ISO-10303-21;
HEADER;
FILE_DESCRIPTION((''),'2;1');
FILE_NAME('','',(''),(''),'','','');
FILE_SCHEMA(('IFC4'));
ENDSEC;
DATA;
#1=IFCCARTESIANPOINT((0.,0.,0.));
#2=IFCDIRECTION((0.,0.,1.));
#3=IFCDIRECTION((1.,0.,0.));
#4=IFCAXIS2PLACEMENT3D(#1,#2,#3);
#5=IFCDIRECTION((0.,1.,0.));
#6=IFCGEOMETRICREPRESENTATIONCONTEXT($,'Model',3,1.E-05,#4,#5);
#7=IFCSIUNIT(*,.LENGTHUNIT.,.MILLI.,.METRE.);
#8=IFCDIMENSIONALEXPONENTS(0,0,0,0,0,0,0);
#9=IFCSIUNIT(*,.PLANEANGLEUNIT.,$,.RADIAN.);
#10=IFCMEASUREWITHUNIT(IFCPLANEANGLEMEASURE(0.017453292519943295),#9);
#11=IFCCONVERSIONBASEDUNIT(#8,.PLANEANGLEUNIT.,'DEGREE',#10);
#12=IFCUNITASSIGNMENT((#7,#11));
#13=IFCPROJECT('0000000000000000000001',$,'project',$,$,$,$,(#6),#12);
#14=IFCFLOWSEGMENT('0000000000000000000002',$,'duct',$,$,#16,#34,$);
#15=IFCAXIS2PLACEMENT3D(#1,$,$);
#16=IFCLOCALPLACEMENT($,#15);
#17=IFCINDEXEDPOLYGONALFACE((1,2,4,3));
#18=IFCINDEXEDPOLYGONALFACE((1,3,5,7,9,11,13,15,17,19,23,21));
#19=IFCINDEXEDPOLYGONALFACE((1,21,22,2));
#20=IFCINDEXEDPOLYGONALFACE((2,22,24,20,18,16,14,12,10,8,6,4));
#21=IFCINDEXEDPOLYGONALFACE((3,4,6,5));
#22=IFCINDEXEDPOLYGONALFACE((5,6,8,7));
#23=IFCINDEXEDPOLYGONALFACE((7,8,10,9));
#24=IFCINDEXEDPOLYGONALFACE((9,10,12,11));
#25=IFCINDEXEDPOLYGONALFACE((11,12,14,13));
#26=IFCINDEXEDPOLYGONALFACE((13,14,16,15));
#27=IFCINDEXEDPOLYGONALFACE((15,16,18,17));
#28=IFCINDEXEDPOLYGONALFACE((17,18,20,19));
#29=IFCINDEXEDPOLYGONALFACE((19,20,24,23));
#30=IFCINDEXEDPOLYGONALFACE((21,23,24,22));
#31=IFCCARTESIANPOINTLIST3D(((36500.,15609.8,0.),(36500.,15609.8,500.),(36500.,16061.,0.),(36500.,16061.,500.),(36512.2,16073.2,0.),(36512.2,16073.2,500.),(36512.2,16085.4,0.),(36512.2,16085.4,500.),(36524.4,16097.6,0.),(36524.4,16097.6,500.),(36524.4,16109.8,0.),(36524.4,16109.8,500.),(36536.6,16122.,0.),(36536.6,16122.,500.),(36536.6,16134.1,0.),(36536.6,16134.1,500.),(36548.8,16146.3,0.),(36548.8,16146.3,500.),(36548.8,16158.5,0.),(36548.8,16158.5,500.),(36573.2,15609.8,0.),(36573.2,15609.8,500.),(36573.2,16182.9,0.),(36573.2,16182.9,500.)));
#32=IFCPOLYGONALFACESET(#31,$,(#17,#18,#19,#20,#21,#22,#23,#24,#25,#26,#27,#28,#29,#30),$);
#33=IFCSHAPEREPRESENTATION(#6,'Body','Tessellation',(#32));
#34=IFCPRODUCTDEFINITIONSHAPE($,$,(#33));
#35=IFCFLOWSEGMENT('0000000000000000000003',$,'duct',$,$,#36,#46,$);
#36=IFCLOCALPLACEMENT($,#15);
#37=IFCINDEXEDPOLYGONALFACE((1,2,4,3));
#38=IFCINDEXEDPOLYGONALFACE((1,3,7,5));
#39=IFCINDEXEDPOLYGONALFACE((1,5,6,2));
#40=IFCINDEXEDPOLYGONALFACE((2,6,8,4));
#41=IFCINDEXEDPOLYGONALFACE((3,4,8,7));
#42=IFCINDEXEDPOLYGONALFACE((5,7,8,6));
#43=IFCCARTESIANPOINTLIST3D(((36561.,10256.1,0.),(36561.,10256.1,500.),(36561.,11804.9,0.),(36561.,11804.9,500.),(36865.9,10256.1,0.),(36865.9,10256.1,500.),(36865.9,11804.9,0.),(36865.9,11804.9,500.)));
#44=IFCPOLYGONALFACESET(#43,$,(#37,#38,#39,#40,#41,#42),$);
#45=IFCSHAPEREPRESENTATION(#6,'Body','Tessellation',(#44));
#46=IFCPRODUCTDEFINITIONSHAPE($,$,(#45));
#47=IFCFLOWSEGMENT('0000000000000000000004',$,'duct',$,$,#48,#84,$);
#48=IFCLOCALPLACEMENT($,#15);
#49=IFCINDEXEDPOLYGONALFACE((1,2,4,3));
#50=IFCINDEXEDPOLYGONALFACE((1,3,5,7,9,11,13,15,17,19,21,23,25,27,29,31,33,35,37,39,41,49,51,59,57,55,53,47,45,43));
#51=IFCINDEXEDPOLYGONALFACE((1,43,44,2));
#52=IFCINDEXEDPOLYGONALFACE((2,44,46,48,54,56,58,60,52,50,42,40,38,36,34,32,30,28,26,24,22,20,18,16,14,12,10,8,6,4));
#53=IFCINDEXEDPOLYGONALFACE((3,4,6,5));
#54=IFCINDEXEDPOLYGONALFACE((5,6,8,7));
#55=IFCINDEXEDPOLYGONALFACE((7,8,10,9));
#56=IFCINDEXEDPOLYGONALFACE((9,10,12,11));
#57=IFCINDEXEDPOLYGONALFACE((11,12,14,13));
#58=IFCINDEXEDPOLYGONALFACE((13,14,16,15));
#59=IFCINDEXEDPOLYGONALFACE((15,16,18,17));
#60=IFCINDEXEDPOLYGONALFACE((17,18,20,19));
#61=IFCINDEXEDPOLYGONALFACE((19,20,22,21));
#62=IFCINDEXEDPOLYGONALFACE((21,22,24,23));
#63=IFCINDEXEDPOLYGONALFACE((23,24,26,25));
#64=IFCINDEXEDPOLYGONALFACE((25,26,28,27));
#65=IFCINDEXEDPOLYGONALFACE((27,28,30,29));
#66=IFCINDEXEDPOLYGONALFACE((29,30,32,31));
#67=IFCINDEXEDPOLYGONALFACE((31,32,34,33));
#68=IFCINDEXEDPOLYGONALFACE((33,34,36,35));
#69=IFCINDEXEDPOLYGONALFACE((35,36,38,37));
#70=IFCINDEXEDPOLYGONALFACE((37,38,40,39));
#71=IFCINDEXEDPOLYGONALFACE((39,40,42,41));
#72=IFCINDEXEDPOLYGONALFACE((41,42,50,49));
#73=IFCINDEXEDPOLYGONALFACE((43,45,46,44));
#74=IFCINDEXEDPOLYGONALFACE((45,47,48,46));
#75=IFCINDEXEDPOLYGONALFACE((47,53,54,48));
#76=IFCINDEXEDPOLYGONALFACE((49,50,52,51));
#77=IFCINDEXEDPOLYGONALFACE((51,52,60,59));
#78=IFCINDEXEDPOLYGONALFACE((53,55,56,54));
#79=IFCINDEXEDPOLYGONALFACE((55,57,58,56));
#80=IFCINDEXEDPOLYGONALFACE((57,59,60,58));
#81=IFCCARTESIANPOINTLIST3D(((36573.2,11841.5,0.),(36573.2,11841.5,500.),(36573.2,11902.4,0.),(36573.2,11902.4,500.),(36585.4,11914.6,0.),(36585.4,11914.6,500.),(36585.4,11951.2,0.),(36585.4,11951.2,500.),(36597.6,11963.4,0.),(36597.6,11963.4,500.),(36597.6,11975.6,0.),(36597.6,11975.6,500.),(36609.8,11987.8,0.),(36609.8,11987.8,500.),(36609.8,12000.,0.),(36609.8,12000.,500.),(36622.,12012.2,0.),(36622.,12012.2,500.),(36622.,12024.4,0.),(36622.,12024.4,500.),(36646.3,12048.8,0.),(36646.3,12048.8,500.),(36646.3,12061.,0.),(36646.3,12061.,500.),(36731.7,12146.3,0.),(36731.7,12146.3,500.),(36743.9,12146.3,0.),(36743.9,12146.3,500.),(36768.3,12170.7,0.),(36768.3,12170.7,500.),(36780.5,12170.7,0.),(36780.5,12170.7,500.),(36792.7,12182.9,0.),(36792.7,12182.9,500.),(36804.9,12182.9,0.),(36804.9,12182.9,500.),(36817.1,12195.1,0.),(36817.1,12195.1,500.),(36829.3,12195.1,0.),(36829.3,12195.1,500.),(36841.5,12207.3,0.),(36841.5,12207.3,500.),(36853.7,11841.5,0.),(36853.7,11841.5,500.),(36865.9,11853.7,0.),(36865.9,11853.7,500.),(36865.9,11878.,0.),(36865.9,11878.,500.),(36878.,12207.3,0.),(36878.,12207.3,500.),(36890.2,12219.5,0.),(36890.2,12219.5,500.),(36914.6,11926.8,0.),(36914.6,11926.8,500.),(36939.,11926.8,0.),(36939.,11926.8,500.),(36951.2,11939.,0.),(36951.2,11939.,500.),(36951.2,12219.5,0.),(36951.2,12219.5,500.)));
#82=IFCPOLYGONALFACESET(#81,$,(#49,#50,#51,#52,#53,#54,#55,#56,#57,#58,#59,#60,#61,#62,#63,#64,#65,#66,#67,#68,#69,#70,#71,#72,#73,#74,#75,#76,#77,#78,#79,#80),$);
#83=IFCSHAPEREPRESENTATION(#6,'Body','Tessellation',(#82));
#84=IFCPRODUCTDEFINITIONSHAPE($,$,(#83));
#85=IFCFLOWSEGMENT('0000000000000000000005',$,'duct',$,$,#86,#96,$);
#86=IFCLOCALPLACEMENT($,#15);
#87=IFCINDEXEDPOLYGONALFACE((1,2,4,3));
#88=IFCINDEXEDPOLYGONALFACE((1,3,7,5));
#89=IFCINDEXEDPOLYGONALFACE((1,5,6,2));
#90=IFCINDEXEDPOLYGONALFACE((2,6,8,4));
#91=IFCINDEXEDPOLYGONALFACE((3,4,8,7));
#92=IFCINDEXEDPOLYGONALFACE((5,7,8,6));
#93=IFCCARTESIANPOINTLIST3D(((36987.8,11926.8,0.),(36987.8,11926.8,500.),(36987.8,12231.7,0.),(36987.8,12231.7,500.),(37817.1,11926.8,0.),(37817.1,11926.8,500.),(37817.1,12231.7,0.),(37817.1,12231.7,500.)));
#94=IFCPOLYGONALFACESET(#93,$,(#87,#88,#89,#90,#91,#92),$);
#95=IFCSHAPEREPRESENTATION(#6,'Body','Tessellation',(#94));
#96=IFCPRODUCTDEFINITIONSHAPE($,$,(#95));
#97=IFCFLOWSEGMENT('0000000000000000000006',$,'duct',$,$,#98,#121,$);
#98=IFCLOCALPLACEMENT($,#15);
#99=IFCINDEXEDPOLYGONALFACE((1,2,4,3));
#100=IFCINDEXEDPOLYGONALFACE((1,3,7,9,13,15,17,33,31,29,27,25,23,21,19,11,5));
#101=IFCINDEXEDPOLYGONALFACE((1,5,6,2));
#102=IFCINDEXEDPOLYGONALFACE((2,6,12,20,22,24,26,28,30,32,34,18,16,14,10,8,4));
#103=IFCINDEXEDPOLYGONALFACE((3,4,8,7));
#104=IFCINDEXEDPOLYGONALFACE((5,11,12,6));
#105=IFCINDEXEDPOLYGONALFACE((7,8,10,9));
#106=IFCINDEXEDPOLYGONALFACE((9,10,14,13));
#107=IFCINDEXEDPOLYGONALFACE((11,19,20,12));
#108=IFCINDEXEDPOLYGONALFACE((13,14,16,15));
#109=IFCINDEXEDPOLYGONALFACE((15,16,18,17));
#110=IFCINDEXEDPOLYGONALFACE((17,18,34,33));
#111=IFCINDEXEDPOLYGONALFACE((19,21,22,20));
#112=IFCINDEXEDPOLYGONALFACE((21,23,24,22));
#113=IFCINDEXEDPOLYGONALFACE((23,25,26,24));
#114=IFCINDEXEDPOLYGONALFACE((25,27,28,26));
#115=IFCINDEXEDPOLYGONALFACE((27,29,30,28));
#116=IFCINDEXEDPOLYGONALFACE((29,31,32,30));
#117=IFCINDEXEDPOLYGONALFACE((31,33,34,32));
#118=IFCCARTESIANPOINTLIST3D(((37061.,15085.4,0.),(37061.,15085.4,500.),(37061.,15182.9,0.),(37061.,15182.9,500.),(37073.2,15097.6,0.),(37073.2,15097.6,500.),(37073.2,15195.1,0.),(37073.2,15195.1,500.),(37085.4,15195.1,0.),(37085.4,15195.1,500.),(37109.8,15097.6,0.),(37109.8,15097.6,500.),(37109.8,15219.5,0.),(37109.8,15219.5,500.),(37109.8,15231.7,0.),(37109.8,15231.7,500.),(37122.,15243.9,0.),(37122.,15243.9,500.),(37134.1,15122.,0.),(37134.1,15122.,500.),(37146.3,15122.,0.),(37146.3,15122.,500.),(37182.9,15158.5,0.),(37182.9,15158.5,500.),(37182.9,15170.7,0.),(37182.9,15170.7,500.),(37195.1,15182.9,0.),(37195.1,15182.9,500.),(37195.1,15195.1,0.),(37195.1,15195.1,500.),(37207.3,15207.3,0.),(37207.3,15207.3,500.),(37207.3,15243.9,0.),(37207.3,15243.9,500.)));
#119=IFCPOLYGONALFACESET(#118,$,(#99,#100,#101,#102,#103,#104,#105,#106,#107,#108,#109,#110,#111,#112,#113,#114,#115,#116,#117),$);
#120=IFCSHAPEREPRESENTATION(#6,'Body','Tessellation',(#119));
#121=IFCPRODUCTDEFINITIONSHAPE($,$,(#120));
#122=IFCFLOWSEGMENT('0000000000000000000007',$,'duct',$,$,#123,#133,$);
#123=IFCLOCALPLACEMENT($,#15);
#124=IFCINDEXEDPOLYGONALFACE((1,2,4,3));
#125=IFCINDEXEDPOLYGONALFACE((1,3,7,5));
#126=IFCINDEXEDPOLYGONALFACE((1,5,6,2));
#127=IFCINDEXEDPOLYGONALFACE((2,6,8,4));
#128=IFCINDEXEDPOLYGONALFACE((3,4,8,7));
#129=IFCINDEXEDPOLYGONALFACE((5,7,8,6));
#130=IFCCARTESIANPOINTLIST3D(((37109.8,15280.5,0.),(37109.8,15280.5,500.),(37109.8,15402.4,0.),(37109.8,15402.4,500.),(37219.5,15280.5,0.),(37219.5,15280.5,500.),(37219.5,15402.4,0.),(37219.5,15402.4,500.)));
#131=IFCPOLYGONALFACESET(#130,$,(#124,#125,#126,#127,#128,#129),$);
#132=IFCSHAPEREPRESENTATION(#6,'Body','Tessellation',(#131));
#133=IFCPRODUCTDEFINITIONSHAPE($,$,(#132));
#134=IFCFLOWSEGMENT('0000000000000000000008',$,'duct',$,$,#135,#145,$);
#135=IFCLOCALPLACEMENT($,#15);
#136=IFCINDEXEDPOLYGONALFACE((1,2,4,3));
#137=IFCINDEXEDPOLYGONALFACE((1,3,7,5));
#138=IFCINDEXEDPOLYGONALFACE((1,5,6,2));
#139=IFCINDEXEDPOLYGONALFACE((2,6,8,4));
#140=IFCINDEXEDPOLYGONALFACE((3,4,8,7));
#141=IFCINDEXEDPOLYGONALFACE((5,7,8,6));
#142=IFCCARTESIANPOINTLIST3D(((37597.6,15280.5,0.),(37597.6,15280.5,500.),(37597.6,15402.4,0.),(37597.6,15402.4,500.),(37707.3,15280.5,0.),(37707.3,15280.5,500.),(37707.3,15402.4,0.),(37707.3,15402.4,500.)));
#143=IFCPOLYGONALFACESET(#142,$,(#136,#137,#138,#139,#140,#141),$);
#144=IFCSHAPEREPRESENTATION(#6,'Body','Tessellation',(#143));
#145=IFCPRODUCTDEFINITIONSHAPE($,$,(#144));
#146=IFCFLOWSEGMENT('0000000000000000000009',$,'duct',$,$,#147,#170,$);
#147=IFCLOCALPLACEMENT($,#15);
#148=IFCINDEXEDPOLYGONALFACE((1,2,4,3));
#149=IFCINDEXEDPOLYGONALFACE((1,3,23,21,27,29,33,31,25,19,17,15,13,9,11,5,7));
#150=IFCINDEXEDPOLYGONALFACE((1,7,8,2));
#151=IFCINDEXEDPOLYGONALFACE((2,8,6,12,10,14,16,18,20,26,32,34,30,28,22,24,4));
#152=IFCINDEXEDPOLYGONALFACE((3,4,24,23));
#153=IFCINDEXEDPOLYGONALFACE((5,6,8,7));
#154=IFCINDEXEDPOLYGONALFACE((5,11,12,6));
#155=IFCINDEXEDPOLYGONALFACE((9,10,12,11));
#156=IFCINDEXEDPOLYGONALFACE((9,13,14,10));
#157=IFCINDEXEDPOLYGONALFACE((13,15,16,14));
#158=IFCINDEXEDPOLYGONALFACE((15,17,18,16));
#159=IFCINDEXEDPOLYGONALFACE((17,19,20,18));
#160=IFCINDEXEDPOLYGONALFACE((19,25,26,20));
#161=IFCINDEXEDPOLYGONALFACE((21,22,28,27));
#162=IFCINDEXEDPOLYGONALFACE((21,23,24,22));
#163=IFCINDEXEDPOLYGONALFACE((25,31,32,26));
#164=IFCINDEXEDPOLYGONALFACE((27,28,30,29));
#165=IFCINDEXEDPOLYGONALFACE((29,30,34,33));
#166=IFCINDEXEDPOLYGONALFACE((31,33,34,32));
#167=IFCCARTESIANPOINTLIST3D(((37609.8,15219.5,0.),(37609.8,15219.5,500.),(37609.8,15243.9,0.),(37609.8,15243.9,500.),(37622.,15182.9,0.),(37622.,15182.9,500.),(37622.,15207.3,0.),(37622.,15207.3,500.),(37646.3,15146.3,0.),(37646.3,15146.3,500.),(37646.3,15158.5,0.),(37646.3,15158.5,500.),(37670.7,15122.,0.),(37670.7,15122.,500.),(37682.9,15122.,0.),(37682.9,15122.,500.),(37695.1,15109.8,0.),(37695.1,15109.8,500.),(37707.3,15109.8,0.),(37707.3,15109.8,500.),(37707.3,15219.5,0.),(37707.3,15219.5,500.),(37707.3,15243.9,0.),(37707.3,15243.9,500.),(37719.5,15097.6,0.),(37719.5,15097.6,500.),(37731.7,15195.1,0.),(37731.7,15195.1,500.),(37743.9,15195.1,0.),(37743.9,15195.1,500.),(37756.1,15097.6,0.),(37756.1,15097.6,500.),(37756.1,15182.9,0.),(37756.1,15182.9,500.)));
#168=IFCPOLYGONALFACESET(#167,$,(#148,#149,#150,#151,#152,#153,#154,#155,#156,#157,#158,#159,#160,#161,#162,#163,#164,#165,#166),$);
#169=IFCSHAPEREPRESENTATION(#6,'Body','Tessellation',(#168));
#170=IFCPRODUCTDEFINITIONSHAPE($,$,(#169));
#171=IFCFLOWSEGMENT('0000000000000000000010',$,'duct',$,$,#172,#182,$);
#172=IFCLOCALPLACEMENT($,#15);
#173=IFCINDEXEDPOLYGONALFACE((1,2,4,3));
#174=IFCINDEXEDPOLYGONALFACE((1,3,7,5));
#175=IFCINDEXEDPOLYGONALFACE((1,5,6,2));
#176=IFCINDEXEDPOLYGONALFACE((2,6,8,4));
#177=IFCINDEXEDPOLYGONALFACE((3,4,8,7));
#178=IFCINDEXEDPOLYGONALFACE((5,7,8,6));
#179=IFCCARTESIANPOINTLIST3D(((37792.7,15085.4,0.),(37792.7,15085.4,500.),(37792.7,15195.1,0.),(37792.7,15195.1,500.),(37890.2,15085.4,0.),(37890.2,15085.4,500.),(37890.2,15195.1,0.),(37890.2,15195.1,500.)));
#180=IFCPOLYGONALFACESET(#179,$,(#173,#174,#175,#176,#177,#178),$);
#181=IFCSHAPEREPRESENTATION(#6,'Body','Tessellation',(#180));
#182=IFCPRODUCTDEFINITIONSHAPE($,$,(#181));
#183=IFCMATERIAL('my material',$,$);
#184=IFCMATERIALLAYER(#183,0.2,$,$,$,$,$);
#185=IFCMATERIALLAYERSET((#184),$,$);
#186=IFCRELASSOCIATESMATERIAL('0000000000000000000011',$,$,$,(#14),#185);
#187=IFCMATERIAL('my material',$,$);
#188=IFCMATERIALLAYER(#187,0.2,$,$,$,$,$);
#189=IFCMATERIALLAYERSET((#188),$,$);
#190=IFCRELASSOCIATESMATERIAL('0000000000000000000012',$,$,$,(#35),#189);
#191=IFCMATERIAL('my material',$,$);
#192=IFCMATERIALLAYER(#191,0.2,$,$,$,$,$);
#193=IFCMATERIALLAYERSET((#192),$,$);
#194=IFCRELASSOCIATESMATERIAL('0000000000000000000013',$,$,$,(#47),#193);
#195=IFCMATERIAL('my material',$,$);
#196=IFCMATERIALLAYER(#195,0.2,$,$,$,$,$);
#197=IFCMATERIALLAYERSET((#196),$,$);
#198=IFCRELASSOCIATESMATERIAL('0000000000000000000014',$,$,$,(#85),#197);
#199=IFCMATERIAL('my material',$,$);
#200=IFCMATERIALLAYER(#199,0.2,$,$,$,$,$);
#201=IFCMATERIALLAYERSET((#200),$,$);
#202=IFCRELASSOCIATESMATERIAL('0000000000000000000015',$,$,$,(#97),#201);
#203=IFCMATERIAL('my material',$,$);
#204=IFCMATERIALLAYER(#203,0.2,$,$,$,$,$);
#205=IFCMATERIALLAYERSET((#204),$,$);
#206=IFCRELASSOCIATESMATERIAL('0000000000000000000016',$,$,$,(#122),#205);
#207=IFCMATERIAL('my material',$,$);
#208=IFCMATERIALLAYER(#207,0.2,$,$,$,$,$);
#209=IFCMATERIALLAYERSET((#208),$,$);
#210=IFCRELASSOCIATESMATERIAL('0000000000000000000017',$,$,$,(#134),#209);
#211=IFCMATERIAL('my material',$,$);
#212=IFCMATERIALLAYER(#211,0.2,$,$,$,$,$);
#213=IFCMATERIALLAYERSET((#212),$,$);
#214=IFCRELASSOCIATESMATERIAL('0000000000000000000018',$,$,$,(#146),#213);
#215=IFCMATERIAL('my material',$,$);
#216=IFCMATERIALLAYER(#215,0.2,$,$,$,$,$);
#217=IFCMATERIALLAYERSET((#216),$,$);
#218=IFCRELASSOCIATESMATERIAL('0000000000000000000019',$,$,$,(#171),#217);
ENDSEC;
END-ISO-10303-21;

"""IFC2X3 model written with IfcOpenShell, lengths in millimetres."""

from ifc_helpers import new_model, entity, si_unit, converted_unit, direction, origin_with_axes, place, context, project, polyline, outline, extrude, material, layer, layer_set, layer_usage, element, save


model = new_model("IFC2X3")

# Units and contexts
model_context = context("Model", 3, precision=1e-05, world=origin_with_axes(), true_north=direction((0.0, 1.0, 0.0)))
ifc_project = project(units=[si_unit("LENGTHUNIT", "METRE", prefix="MILLI"), converted_unit("PLANEANGLEUNIT", "DEGREE", entity("IfcPlaneAngleMeasure", 0.017453292519943295), si_unit("PLANEANGLEUNIT", "RADIAN"), dimensions=[0, 0, 0, 0, 0, 0, 0])], contexts=[model_context])

# Flow segments
ifc_material_1 = material(Name="my material")
ifc_layer_1 = layer(ifc_material_1, 0.2)
ifc_layer_set_1 = layer_set([ifc_layer_1])
ifc_layer_usage_1 = layer_usage(ifc_layer_set_1, "AXIS2", "POSITIVE", -0.1)
flow_segment_1_placement = place(None, origin_with_axes())
element("IfcFlowSegment", 1, at=flow_segment_1_placement, material=ifc_layer_usage_1, Name="duct", context=model_context, shape_type="SweptSolid", body=[
    extrude(outline(polyline([(36500.0, 15609.8), (36573.2, 15609.8), (36573.2, 16195.1), (36573.2, 16182.9), (36548.8, 16158.5), (36548.8, 16146.3), (36536.6, 16134.1), (36536.6, 16122.0), (36524.4, 16109.8), (36524.4, 16097.6), (36512.2, 16085.4), (36512.2, 16073.2), (36500.0, 16061.0), (36500.0, 15609.8)])), origin_with_axes(), (0.0, 0.0, 1.0), 500.0),
])
ifc_material_2 = material(Name="my material")
ifc_layer_2 = layer(ifc_material_2, 0.2)
ifc_layer_set_2 = layer_set([ifc_layer_2])
ifc_layer_usage_2 = layer_usage(ifc_layer_set_2, "AXIS2", "POSITIVE", -0.1)
flow_segment_2_placement = place(None, origin_with_axes())
element("IfcFlowSegment", 2, at=flow_segment_2_placement, material=ifc_layer_usage_2, Name="duct", context=model_context, shape_type="SweptSolid", body=[
    extrude(outline(polyline([(36561.0, 10256.1), (36865.9, 10256.1), (36865.9, 11804.9), (36561.0, 11804.9), (36561.0, 10256.1)])), origin_with_axes(), (0.0, 0.0, 1.0), 500.0),
])
ifc_material_3 = material(Name="my material")
ifc_layer_3 = layer(ifc_material_3, 0.2)
ifc_layer_set_3 = layer_set([ifc_layer_3])
ifc_layer_usage_3 = layer_usage(ifc_layer_set_3, "AXIS2", "POSITIVE", -0.1)
flow_segment_3_placement = place(None, origin_with_axes())
element("IfcFlowSegment", 3, at=flow_segment_3_placement, material=ifc_layer_usage_3, Name="duct", context=model_context, shape_type="SweptSolid", body=[
    extrude(outline(polyline([(36573.2, 11841.5), (36853.7, 11841.5), (36865.9, 11853.7), (36865.9, 11878.0), (36914.6, 11926.8), (36939.0, 11926.8), (36951.2, 11939.0), (36951.2, 12219.5), (36890.2, 12219.5), (36878.0, 12207.3), (36841.5, 12207.3), (36829.3, 12195.1), (36817.1, 12195.1), (36804.9, 12182.9), (36792.7, 12182.9), (36780.5, 12170.7), (36768.3, 12170.7), (36743.9, 12146.3), (36731.7, 12146.3), (36646.3, 12061.0), (36646.3, 12048.8), (36622.0, 12024.4), (36622.0, 12012.2), (36609.8, 12000.0), (36609.8, 11987.8), (36597.6, 11975.6), (36597.6, 11963.4), (36585.4, 11951.2), (36585.4, 11914.6), (36573.2, 11902.4), (36573.2, 11841.5)])), origin_with_axes(), (0.0, 0.0, 1.0), 500.0),
])
ifc_material_4 = material(Name="my material")
ifc_layer_4 = layer(ifc_material_4, 0.2)
ifc_layer_set_4 = layer_set([ifc_layer_4])
ifc_layer_usage_4 = layer_usage(ifc_layer_set_4, "AXIS2", "POSITIVE", -0.1)
flow_segment_4_placement = place(None, origin_with_axes())
element("IfcFlowSegment", 4, at=flow_segment_4_placement, material=ifc_layer_usage_4, Name="duct", context=model_context, shape_type="SweptSolid", body=[
    extrude(outline(polyline([(36987.8, 11926.8), (37817.1, 11926.8), (37817.1, 12231.7), (36987.8, 12231.7), (36987.8, 11926.8)])), origin_with_axes(), (0.0, 0.0, 1.0), 500.0),
])
ifc_material_5 = material(Name="my material")
ifc_layer_5 = layer(ifc_material_5, 0.2)
ifc_layer_set_5 = layer_set([ifc_layer_5])
ifc_layer_usage_5 = layer_usage(ifc_layer_set_5, "AXIS2", "POSITIVE", -0.1)
flow_segment_5_placement = place(None, origin_with_axes())
element("IfcFlowSegment", 5, at=flow_segment_5_placement, material=ifc_layer_usage_5, Name="duct", context=model_context, shape_type="SweptSolid", body=[
    extrude(outline(polyline([(37061.0, 15085.4), (37073.2, 15097.6), (37109.8, 15097.6), (37134.1, 15122.0), (37146.3, 15122.0), (37182.9, 15158.5), (37182.9, 15170.7), (37195.1, 15182.9), (37195.1, 15195.1), (37207.3, 15207.3), (37207.3, 15243.9), (37122.0, 15243.9), (37109.8, 15231.7), (37109.8, 15219.5), (37085.4, 15195.1), (37073.2, 15195.1), (37061.0, 15182.9), (37061.0, 15085.4)])), origin_with_axes(), (0.0, 0.0, 1.0), 500.0),
])
ifc_material_6 = material(Name="my material")
ifc_layer_6 = layer(ifc_material_6, 0.2)
ifc_layer_set_6 = layer_set([ifc_layer_6])
ifc_layer_usage_6 = layer_usage(ifc_layer_set_6, "AXIS2", "POSITIVE", -0.1)
flow_segment_6_placement = place(None, origin_with_axes())
element("IfcFlowSegment", 6, at=flow_segment_6_placement, material=ifc_layer_usage_6, Name="duct", context=model_context, shape_type="SweptSolid", body=[
    extrude(outline(polyline([(37109.8, 15280.5), (37219.5, 15280.5), (37219.5, 15402.4), (37109.8, 15402.4), (37109.8, 15280.5)])), origin_with_axes(), (0.0, 0.0, 1.0), 500.0),
])
ifc_material_7 = material(Name="my material")
ifc_layer_7 = layer(ifc_material_7, 0.2)
ifc_layer_set_7 = layer_set([ifc_layer_7])
ifc_layer_usage_7 = layer_usage(ifc_layer_set_7, "AXIS2", "POSITIVE", -0.1)
flow_segment_7_placement = place(None, origin_with_axes())
element("IfcFlowSegment", 7, at=flow_segment_7_placement, material=ifc_layer_usage_7, Name="duct", context=model_context, shape_type="SweptSolid", body=[
    extrude(outline(polyline([(37597.6, 15280.5), (37707.3, 15280.5), (37707.3, 15402.4), (37597.6, 15402.4), (37597.6, 15280.5)])), origin_with_axes(), (0.0, 0.0, 1.0), 500.0),
])
ifc_material_8 = material(Name="my material")
ifc_layer_8 = layer(ifc_material_8, 0.2)
ifc_layer_set_8 = layer_set([ifc_layer_8])
ifc_layer_usage_8 = layer_usage(ifc_layer_set_8, "AXIS2", "POSITIVE", -0.1)
flow_segment_8_placement = place(None, origin_with_axes())
element("IfcFlowSegment", 8, at=flow_segment_8_placement, material=ifc_layer_usage_8, Name="duct", context=model_context, shape_type="SweptSolid", body=[
    extrude(outline(polyline([(37609.8, 15219.5), (37622.0, 15207.3), (37622.0, 15182.9), (37646.3, 15158.5), (37646.3, 15146.3), (37670.7, 15122.0), (37682.9, 15122.0), (37695.1, 15109.8), (37707.3, 15109.8), (37719.5, 15097.6), (37756.1, 15097.6), (37756.1, 15182.9), (37743.9, 15195.1), (37731.7, 15195.1), (37707.3, 15219.5), (37707.3, 15243.9), (37609.8, 15243.9), (37609.8, 15219.5)])), origin_with_axes(), (0.0, 0.0, 1.0), 500.0),
])
ifc_material_9 = material(Name="my material")
ifc_layer_9 = layer(ifc_material_9, 0.2)
ifc_layer_set_9 = layer_set([ifc_layer_9])
ifc_layer_usage_9 = layer_usage(ifc_layer_set_9, "AXIS2", "POSITIVE", -0.1)
flow_segment_9_placement = place(None, origin_with_axes())
element("IfcFlowSegment", 9, at=flow_segment_9_placement, material=ifc_layer_usage_9, Name="duct", context=model_context, shape_type="SweptSolid", body=[
    extrude(outline(polyline([(37792.7, 15085.4), (37890.2, 15085.4), (37890.2, 15195.1), (37792.7, 15195.1), (37792.7, 15085.4)])), origin_with_axes(), (0.0, 0.0, 1.0), 500.0),
])

save(model, "model.ifc")
